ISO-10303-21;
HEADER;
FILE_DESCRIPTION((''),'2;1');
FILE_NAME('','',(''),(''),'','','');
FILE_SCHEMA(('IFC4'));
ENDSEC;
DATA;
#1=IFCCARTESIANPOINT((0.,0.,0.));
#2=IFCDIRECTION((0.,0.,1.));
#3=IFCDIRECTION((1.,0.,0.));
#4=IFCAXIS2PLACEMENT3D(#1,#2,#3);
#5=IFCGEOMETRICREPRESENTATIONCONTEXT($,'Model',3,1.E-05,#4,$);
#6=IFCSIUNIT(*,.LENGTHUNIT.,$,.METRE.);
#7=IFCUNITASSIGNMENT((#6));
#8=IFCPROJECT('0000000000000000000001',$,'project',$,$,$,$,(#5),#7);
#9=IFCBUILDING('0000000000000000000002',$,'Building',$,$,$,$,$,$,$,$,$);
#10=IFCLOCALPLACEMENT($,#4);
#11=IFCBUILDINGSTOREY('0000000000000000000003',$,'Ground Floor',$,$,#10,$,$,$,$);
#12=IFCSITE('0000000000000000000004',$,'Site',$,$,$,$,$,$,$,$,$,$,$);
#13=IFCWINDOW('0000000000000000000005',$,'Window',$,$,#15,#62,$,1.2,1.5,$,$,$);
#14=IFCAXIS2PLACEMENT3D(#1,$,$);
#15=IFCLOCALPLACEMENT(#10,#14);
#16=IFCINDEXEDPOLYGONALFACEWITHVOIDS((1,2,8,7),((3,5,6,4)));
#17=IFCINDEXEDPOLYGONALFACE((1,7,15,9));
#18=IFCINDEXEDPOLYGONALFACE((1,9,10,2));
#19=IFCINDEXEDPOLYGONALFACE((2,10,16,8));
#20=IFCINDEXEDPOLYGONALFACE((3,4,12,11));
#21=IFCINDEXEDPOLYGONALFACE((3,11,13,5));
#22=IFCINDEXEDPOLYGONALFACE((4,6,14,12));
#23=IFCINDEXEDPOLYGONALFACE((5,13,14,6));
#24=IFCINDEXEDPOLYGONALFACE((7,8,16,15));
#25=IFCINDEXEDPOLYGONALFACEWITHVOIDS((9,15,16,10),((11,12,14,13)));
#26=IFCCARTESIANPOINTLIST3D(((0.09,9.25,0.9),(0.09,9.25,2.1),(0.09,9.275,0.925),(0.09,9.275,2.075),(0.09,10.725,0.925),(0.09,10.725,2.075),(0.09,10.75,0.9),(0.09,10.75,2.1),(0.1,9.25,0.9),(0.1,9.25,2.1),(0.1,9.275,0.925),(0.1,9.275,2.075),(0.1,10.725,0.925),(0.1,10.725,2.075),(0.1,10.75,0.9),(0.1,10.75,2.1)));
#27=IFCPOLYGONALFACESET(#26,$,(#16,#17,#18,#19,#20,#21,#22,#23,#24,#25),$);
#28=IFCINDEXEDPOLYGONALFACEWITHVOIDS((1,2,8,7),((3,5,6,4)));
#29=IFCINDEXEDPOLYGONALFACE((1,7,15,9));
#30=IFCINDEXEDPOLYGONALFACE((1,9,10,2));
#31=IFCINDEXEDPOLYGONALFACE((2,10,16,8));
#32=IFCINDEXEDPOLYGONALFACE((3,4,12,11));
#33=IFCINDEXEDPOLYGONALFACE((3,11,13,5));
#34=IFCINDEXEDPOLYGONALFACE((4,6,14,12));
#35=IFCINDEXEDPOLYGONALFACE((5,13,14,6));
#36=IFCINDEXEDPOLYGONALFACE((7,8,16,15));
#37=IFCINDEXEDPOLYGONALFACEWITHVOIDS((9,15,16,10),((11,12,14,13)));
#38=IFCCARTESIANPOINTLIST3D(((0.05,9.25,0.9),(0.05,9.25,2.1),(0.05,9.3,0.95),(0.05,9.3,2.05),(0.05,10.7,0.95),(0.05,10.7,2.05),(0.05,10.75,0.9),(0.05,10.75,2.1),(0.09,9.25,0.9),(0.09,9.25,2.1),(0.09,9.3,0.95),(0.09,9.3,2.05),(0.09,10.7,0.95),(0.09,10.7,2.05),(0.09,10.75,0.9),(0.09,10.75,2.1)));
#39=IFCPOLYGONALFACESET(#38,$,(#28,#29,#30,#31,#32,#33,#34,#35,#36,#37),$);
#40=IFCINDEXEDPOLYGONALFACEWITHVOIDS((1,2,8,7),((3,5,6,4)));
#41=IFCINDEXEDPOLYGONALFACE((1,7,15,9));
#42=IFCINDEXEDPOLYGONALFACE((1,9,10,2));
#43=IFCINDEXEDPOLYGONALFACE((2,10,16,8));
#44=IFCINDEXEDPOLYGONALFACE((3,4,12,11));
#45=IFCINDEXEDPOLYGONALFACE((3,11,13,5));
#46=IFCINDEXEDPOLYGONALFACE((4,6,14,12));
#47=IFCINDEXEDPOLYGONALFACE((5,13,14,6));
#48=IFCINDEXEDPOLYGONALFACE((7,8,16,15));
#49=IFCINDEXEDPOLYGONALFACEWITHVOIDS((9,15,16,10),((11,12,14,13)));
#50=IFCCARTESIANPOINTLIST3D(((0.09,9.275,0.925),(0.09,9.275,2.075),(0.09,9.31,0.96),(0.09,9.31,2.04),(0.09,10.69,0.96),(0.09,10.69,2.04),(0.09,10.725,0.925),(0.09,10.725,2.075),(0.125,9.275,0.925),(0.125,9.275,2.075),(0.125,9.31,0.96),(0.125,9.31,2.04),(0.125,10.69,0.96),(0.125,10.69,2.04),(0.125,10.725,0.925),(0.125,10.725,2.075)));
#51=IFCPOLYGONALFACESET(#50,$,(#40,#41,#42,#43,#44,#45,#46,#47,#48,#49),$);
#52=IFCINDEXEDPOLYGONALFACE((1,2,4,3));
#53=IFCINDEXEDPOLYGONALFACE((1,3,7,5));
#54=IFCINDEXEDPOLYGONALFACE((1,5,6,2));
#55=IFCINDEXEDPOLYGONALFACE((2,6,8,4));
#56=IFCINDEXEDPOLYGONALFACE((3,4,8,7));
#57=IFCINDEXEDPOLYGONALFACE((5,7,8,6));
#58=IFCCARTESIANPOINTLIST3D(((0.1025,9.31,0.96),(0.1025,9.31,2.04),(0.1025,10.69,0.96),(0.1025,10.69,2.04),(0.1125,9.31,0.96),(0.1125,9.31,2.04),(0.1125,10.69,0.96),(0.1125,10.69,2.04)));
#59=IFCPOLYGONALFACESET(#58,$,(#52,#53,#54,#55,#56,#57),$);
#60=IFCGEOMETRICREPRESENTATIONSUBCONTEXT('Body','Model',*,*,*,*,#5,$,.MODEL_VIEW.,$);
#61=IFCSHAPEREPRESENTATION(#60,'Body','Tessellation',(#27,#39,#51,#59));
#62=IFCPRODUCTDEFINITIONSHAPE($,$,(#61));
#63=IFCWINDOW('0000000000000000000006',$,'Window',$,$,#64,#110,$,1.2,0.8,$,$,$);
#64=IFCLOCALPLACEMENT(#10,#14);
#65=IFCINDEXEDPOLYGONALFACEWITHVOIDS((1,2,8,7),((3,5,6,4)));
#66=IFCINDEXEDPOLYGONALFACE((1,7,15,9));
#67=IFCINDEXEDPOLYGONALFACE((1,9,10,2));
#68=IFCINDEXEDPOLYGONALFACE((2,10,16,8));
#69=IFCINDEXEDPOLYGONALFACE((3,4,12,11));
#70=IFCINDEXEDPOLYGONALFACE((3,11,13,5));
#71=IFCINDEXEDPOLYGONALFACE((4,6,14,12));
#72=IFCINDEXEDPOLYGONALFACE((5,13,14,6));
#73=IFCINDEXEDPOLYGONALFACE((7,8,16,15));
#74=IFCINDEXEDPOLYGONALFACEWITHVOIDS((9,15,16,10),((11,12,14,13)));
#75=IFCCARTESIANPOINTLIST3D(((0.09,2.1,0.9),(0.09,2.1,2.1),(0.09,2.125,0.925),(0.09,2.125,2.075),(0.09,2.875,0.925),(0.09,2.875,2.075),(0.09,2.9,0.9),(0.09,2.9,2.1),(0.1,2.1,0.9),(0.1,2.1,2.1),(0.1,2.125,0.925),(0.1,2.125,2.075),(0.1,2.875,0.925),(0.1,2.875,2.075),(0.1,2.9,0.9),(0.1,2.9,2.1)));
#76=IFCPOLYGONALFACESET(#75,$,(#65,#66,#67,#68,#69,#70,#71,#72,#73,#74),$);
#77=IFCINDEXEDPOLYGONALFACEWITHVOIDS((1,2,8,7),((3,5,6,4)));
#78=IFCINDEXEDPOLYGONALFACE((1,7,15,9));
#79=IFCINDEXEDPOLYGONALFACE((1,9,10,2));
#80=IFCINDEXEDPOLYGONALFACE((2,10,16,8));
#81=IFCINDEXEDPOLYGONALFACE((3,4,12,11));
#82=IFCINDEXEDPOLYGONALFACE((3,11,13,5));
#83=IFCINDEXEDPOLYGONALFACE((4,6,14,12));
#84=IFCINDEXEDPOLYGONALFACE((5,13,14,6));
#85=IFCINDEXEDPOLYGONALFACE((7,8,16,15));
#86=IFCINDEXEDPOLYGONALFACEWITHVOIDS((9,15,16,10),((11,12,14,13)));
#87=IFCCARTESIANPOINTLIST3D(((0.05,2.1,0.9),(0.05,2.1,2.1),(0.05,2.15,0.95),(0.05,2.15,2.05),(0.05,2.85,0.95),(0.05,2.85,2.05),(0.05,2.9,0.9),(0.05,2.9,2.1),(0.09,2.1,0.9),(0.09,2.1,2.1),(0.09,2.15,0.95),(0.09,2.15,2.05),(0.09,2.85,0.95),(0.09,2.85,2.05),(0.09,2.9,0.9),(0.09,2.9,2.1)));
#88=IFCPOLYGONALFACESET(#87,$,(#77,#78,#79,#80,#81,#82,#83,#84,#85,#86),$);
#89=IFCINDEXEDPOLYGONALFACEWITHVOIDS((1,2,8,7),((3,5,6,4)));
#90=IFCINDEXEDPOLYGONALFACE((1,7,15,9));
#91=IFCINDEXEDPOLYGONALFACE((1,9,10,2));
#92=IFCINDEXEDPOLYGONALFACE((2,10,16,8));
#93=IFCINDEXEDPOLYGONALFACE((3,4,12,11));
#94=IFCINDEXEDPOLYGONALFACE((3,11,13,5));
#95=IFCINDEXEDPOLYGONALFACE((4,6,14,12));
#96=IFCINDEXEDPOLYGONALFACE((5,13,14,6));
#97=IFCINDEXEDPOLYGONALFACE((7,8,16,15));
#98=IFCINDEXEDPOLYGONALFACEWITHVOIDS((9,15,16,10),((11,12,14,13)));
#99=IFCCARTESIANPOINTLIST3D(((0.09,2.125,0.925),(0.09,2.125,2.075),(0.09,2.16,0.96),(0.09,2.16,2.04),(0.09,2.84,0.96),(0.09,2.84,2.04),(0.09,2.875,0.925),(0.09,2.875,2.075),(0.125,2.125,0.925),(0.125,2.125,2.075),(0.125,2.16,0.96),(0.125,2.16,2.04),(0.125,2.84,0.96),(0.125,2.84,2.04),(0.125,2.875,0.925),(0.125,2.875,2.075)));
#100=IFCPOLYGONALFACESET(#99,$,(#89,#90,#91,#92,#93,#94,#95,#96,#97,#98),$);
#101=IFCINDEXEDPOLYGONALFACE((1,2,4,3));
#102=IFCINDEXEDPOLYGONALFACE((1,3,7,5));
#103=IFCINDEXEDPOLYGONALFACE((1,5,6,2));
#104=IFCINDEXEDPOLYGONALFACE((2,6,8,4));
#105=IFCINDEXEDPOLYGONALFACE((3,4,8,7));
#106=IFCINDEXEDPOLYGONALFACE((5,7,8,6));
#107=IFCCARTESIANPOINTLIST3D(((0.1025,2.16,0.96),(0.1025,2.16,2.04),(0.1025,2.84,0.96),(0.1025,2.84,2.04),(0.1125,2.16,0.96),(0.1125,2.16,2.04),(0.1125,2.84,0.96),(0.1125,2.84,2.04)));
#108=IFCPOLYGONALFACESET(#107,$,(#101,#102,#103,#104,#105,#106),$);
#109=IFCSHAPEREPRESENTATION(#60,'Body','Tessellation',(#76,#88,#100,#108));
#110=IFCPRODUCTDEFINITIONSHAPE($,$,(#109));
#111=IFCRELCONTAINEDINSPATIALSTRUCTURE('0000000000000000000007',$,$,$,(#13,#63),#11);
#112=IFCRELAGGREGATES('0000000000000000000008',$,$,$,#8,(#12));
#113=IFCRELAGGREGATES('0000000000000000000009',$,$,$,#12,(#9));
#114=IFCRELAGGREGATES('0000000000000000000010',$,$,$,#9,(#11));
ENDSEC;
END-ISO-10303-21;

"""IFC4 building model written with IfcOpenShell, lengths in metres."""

from ifc_helpers import new_model, si_unit, frame, origin_with_axes, place, context, subcontext, project, spatial, line, indexed_curve, outline, extrude, element, save


model = new_model("IFC4")

# Units and contexts
model_context = context("Model", 3, precision=1e-05, world=origin_with_axes())
body_context = subcontext(model_context, "Body", "Model", "MODEL_VIEW")
ifc_project = project(units=[si_unit("LENGTHUNIT", "METRE")], contexts=[model_context])

# Site, building, storey
site = spatial("IfcSite", under=ifc_project, Name="Site")
building = spatial("IfcBuilding", under=site, Name="Building")
storey_placement = place(None, origin_with_axes())
storey = spatial("IfcBuildingStorey", under=building, at=storey_placement, Name="Ground Floor")

# Windows
window_1_placement = place(storey_placement, frame((0.0, 10.75, 0.9), z_axis=(0.0, 0.0, 1.0), x_axis=(0.0, -1.0, 0.0)))
element("IfcWindow", 1, at=window_1_placement, inside=storey, Name="Window", OverallHeight=1.2, OverallWidth=1.5, context=body_context, shape_type="SweptSolid", body=[
    extrude(outline(indexed_curve([(0.0, 0.0), (1.5, 0.0), (1.5, 1.2), (0.0, 1.2)], segments=[line(1, 2, 3, 4, 1)]), holes=[indexed_curve([(0.025, 0.025), (1.475, 0.025), (1.475, 1.175), (0.025, 1.175)], segments=[line(1, 2, 3, 4, 1)])]), frame((0.0, 0.09, 0.0), z_axis=(0.0, -1.0, 0.0), x_axis=(1.0, 0.0, 0.0)), (0.0, 0.0, -1.0), 0.01),
    extrude(outline(indexed_curve([(0.0, 0.0), (1.5, 0.0), (1.5, 1.2), (0.0, 1.2)], segments=[line(1, 2, 3, 4, 1)]), holes=[indexed_curve([(0.05, 0.05), (1.45, 0.05), (1.45, 1.15), (0.05, 1.15)], segments=[line(1, 2, 3, 4, 1)])]), frame((0.0, 0.05, 0.0), z_axis=(0.0, -1.0, 0.0), x_axis=(1.0, 0.0, 0.0)), (0.0, 0.0, -1.0), 0.04),
    extrude(outline(indexed_curve([(0.0, 0.0), (1.45, 0.0), (1.45, 1.15), (0.0, 1.15)], segments=[line(1, 2, 3, 4, 1)]), holes=[indexed_curve([(0.035, 0.035), (1.415, 0.035), (1.415, 1.115), (0.035, 1.115)], segments=[line(1, 2, 3, 4, 1)])]), frame((0.025, 0.09, 0.025), z_axis=(0.0, -1.0, 0.0), x_axis=(1.0, 0.0, 0.0)), (0.0, 0.0, -1.0), 0.035),
    extrude(outline(indexed_curve([(0.035, 0.035), (1.415, 0.035), (1.415, 1.115), (0.035, 1.115)], segments=[line(1, 2, 3, 4, 1)])), frame((0.025, 0.1025, 0.025), z_axis=(0.0, -1.0, 0.0), x_axis=(1.0, 0.0, 0.0)), (0.0, 0.0, -1.0), 0.01),
])
window_2_placement = place(storey_placement, frame((0.0, 2.9, 0.9), z_axis=(0.0, 0.0, 1.0), x_axis=(0.0, -1.0, 0.0)))
element("IfcWindow", 2, at=window_2_placement, inside=storey, Name="Window", OverallHeight=1.2, OverallWidth=0.8, context=body_context, shape_type="SweptSolid", body=[
    extrude(outline(indexed_curve([(0.0, 0.0), (0.8, 0.0), (0.8, 1.2), (0.0, 1.2)], segments=[line(1, 2, 3, 4, 1)]), holes=[indexed_curve([(0.025, 0.025), (0.775, 0.025), (0.775, 1.175), (0.025, 1.175)], segments=[line(1, 2, 3, 4, 1)])]), frame((0.0, 0.09, 0.0), z_axis=(0.0, -1.0, 0.0), x_axis=(1.0, 0.0, 0.0)), (0.0, 0.0, -1.0), 0.01),
    extrude(outline(indexed_curve([(0.0, 0.0), (0.8, 0.0), (0.8, 1.2), (0.0, 1.2)], segments=[line(1, 2, 3, 4, 1)]), holes=[indexed_curve([(0.05, 0.05), (0.75, 0.05), (0.75, 1.15), (0.05, 1.15)], segments=[line(1, 2, 3, 4, 1)])]), frame((0.0, 0.05, 0.0), z_axis=(0.0, -1.0, 0.0), x_axis=(1.0, 0.0, 0.0)), (0.0, 0.0, -1.0), 0.04),
    extrude(outline(indexed_curve([(0.0, 0.0), (0.75, 0.0), (0.75, 1.15), (0.0, 1.15)], segments=[line(1, 2, 3, 4, 1)]), holes=[indexed_curve([(0.035, 0.035), (0.715, 0.035), (0.715, 1.115), (0.035, 1.115)], segments=[line(1, 2, 3, 4, 1)])]), frame((0.025, 0.09, 0.025), z_axis=(0.0, -1.0, 0.0), x_axis=(1.0, 0.0, 0.0)), (0.0, 0.0, -1.0), 0.035),
    extrude(outline(indexed_curve([(0.035, 0.035), (0.715, 0.035), (0.715, 1.115), (0.035, 1.115)], segments=[line(1, 2, 3, 4, 1)])), frame((0.025, 0.1025, 0.025), z_axis=(0.0, -1.0, 0.0), x_axis=(1.0, 0.0, 0.0)), (0.0, 0.0, -1.0), 0.01),
])

save(model, "model.ifc")
